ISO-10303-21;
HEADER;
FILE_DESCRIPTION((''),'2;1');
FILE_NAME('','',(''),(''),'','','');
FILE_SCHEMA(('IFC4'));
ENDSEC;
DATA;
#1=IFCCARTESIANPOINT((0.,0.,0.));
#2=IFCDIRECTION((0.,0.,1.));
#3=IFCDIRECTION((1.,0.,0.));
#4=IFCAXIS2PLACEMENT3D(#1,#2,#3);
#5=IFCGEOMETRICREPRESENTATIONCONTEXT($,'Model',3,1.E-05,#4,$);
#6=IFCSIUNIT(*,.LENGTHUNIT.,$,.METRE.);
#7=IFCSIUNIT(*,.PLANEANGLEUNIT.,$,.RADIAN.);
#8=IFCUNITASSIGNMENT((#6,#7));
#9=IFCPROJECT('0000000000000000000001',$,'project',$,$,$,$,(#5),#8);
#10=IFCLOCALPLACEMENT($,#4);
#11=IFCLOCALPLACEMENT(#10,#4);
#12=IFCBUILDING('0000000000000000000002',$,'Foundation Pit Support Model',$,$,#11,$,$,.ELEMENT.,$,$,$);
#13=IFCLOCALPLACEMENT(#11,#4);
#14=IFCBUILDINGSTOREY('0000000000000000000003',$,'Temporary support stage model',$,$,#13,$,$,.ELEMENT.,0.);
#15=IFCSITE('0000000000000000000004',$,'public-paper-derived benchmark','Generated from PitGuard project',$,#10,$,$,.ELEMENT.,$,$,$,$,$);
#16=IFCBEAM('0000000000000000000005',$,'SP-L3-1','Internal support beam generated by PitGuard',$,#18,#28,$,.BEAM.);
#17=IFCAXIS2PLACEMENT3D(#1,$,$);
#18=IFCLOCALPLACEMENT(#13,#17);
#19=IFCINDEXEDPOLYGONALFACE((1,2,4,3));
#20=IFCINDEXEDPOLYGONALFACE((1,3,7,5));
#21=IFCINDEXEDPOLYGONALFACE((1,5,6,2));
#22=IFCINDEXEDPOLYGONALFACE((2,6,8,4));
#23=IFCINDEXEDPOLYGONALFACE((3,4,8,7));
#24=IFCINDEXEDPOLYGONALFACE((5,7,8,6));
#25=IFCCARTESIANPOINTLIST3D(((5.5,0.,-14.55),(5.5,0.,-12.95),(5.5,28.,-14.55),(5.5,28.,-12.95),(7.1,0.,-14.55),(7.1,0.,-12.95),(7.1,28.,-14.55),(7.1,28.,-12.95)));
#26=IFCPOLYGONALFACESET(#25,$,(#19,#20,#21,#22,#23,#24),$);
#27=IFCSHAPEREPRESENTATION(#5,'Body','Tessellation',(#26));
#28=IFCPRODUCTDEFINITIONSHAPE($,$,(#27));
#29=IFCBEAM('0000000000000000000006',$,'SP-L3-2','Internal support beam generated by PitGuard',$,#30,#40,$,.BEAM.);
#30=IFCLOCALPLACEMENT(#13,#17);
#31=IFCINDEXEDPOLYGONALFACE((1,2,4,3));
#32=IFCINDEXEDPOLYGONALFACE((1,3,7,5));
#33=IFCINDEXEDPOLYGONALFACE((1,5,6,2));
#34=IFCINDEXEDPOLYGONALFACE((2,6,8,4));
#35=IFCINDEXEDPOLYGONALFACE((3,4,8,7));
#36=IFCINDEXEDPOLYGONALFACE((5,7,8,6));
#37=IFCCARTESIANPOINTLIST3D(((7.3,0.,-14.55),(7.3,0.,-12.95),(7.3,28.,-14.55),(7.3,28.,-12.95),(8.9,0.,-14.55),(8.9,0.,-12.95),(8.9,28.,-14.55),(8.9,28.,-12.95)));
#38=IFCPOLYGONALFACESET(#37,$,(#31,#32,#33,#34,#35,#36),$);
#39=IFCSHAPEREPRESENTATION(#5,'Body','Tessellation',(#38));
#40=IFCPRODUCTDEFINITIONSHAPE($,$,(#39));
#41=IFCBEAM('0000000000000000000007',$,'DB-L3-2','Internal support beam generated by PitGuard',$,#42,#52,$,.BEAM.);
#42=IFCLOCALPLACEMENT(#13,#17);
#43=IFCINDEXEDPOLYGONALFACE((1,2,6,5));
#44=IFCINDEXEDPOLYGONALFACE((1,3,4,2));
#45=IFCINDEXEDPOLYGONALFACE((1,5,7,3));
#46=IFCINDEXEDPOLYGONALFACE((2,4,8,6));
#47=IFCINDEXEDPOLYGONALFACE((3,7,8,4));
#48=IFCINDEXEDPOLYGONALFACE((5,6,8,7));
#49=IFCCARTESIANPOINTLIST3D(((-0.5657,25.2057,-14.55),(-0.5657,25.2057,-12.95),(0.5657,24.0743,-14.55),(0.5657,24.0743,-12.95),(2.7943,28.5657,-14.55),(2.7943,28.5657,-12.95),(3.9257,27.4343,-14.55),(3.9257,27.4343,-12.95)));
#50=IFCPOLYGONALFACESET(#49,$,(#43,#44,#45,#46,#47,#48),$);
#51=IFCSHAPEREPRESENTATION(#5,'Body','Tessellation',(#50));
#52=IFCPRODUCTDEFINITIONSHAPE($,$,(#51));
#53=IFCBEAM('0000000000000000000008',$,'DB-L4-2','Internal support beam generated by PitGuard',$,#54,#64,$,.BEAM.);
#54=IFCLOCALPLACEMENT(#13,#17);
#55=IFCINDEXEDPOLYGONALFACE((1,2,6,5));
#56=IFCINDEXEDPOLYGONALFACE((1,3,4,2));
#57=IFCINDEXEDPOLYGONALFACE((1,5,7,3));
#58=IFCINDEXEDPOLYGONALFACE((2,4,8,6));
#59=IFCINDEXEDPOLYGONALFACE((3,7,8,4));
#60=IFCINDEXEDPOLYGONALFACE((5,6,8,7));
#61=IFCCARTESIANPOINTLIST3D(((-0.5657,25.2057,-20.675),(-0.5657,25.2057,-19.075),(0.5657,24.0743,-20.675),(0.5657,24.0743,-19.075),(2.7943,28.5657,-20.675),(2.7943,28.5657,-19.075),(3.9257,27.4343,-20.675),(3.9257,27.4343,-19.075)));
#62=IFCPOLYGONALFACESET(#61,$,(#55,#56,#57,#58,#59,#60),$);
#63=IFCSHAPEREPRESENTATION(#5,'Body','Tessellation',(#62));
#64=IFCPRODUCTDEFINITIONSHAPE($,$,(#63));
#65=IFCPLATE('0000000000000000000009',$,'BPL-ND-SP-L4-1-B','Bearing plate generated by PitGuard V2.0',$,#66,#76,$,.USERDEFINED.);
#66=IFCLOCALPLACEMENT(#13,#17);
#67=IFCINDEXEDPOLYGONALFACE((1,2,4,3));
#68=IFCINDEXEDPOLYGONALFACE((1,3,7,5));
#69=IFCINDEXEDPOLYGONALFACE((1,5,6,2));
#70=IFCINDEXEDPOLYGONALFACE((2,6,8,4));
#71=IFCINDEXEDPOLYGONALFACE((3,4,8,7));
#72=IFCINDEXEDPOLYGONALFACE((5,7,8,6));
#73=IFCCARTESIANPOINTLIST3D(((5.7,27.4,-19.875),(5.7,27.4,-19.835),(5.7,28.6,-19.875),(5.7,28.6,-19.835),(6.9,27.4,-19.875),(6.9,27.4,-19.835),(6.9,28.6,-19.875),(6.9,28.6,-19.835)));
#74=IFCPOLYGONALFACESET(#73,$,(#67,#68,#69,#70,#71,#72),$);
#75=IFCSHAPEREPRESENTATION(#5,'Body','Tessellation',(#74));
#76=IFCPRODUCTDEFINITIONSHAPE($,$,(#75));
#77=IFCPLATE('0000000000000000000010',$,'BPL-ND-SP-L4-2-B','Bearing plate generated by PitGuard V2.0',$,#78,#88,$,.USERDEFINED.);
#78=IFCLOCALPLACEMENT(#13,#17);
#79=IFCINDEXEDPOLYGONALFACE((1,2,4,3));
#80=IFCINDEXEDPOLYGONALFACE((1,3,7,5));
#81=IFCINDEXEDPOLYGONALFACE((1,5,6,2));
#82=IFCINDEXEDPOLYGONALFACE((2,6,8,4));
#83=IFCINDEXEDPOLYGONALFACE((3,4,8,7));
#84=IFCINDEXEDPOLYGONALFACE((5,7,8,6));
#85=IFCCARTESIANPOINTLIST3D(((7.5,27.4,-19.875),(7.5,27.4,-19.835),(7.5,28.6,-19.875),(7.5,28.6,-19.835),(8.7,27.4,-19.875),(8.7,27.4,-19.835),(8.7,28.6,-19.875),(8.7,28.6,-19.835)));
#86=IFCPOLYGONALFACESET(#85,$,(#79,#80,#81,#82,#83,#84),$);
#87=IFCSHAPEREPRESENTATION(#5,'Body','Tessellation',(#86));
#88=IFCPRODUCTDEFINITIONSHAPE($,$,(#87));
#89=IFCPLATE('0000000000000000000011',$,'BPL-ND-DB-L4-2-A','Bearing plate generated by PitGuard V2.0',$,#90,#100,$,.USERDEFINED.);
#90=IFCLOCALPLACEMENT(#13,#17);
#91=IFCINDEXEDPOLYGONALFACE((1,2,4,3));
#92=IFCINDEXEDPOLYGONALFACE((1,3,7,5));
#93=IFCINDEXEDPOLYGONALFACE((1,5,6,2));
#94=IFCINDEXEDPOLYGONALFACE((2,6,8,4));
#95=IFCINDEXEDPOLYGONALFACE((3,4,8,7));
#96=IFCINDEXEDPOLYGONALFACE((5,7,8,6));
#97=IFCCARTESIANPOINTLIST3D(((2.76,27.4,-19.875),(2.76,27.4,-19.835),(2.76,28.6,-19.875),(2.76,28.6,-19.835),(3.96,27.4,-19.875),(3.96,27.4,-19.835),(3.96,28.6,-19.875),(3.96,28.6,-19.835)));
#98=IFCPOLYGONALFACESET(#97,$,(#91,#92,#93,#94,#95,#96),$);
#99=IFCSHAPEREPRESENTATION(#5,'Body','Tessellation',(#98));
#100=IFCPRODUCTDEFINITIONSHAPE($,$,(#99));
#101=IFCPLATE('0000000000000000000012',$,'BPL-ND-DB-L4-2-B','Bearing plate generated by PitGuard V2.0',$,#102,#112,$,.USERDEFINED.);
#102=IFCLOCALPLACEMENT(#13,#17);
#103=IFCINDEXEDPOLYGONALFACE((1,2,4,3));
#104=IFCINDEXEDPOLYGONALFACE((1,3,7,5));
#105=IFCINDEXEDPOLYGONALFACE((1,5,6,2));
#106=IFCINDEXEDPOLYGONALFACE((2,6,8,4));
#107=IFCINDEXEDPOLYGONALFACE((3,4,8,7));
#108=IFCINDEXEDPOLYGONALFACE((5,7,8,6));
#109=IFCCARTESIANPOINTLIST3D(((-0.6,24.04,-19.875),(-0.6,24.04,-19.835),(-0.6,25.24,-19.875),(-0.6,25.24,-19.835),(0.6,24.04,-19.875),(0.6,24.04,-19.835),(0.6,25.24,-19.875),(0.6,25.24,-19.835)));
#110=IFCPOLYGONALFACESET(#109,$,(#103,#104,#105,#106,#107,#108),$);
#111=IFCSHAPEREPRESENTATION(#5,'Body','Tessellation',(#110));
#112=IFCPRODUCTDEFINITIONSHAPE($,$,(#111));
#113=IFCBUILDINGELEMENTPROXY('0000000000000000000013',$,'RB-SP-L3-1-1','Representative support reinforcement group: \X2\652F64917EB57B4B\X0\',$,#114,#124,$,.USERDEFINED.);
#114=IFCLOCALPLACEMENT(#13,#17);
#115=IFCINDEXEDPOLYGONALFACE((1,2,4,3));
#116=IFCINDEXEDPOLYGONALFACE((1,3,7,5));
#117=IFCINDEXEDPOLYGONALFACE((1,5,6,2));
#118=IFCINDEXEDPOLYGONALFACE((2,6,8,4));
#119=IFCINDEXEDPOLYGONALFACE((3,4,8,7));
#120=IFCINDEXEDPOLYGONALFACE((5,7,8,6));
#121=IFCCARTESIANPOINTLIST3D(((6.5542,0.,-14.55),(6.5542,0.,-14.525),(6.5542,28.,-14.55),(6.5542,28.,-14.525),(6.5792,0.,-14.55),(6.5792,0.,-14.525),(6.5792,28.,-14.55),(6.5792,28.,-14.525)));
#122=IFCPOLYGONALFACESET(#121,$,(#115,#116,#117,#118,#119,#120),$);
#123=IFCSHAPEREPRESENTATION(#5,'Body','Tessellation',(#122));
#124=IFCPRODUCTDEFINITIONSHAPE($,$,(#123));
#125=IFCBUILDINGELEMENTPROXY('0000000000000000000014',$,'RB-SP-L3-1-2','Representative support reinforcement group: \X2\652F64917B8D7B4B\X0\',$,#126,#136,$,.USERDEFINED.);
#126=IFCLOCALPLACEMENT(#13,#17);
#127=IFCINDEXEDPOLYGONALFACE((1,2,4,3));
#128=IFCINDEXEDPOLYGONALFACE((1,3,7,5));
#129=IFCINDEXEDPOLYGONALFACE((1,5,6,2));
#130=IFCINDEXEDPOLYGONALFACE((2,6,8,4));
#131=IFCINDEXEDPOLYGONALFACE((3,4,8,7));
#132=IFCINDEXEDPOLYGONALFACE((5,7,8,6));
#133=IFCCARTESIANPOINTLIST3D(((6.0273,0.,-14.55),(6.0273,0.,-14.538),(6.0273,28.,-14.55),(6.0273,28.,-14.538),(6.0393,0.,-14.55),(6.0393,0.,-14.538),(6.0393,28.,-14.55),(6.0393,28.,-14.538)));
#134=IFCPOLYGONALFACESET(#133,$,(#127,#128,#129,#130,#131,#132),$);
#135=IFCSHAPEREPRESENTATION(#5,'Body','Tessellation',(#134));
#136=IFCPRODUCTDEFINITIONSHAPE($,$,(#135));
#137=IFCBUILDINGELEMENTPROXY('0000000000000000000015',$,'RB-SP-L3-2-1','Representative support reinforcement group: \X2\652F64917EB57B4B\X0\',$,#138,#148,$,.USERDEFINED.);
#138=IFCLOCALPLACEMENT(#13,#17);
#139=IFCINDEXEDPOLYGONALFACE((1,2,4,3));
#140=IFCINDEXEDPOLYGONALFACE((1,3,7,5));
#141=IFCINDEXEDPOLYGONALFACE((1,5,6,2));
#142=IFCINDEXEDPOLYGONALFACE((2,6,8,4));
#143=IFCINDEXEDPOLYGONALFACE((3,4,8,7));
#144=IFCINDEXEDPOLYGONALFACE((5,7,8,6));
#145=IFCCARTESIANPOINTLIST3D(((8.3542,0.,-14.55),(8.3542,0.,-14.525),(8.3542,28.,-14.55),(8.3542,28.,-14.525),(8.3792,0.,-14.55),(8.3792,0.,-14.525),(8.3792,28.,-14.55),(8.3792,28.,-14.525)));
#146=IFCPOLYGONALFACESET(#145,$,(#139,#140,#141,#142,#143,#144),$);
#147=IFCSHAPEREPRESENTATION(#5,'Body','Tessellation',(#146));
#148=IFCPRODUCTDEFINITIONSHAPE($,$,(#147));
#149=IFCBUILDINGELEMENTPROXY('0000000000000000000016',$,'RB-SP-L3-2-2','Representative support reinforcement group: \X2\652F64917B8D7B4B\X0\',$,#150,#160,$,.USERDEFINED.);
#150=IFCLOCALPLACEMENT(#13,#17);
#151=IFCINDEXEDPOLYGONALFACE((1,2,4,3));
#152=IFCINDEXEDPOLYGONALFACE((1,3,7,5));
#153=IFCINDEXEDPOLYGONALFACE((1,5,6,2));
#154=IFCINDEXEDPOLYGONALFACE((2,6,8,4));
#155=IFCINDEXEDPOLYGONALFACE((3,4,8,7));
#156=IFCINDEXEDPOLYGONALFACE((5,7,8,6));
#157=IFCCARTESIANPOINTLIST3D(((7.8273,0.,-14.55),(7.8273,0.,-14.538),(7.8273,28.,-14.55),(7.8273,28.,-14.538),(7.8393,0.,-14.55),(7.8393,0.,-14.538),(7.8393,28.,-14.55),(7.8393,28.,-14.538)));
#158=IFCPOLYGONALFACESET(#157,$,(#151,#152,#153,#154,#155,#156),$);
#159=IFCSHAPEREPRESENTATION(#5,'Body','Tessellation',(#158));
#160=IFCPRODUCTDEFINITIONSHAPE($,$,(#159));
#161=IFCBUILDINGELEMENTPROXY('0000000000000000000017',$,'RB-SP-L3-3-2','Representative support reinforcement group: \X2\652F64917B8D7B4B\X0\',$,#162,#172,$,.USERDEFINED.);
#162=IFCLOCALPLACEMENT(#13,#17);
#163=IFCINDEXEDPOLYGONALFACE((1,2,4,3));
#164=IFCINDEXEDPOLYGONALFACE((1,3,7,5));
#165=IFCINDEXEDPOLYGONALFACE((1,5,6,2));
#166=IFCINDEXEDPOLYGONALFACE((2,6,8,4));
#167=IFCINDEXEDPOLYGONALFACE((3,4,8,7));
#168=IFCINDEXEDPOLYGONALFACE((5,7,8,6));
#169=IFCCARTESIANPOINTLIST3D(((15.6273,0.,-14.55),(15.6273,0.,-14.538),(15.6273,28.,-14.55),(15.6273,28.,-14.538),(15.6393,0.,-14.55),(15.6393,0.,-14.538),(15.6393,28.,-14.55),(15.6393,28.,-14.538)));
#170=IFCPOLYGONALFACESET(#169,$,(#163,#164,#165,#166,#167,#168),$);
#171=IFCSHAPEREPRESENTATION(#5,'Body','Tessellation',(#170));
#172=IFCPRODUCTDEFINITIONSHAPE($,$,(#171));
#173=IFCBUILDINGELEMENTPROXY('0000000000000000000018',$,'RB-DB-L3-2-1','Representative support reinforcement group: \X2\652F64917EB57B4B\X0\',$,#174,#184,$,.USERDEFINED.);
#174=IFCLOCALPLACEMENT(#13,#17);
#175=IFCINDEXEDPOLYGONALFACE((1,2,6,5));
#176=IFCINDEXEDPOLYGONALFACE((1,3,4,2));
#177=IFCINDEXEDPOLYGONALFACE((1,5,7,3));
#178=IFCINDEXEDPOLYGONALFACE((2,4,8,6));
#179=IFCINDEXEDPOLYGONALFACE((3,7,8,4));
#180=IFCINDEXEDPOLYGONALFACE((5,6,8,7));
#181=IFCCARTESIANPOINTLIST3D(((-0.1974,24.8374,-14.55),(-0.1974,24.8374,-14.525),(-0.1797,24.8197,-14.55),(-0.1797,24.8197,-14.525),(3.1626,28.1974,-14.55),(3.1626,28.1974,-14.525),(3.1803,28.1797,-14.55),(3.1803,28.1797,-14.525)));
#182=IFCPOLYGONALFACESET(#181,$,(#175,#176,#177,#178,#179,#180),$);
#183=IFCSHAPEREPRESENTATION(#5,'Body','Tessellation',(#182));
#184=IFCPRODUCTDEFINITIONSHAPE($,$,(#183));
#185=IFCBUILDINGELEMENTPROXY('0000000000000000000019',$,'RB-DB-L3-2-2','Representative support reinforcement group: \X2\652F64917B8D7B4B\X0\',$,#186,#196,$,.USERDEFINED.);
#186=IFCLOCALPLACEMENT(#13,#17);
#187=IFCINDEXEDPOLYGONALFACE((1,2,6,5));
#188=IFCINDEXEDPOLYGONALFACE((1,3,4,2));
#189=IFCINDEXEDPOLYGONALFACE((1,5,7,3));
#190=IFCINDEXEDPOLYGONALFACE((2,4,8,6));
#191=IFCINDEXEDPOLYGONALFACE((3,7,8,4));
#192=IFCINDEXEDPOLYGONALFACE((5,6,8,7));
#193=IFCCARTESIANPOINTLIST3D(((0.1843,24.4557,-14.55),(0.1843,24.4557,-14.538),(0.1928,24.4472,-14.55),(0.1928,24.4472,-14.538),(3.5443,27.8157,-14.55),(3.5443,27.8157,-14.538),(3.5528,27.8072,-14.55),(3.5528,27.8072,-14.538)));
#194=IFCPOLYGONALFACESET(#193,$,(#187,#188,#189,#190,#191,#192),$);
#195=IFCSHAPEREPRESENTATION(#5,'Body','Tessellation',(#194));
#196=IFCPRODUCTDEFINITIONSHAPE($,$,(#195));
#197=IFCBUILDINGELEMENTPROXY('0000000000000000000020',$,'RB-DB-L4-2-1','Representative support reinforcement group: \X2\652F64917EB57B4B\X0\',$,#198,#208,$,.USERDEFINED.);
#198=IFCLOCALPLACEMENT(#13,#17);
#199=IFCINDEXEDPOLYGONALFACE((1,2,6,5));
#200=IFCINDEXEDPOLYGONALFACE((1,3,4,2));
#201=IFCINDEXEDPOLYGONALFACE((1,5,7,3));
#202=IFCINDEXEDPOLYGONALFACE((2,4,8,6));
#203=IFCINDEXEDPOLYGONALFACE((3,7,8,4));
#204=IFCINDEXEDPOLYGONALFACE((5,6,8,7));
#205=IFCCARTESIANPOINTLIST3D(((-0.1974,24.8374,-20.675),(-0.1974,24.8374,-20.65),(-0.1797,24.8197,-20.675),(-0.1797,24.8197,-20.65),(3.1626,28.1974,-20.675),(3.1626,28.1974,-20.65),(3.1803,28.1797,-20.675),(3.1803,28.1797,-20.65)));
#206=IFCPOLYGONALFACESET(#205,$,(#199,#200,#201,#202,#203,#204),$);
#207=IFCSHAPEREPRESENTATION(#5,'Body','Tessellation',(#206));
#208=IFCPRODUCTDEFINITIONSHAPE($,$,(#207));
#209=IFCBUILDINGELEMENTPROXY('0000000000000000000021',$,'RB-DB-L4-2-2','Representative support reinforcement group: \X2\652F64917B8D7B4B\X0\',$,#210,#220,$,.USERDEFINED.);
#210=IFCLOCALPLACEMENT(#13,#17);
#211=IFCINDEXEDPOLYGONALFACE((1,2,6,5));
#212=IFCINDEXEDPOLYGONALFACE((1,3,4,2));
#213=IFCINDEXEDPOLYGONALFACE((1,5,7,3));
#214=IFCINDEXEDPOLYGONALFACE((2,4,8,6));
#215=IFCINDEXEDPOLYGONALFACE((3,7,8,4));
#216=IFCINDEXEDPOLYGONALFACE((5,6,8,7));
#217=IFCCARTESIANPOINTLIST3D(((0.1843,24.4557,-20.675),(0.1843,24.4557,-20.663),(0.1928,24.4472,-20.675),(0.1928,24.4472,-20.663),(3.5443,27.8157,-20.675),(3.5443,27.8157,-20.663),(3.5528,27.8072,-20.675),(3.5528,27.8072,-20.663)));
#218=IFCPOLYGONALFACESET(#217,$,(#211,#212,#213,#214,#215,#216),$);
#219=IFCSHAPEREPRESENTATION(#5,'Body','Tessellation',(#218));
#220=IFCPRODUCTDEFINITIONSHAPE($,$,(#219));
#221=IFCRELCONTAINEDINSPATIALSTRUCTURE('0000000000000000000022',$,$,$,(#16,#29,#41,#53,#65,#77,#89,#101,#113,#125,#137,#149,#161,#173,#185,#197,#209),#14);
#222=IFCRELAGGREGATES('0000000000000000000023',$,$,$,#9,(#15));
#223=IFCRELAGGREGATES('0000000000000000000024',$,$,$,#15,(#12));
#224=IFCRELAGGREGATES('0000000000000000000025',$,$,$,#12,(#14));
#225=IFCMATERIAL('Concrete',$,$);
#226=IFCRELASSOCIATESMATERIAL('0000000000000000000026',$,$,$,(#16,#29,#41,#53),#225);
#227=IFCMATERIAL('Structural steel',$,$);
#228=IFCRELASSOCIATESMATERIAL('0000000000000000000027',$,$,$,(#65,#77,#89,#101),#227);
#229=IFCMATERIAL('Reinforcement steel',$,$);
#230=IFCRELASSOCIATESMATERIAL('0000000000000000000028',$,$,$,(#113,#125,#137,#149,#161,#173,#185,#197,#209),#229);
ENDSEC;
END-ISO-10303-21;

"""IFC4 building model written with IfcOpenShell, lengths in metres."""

from ifc_helpers import new_model, si_unit, frame, origin_with_axes, origin_2d, place, context, project, spatial, rectangle, extrude, material, element, save


model = new_model("IFC4")

# Units and contexts
model_context = context("Model", 3, precision=1e-05, world=origin_with_axes())
ifc_project = project(units=[si_unit("LENGTHUNIT", "METRE"), si_unit("PLANEANGLEUNIT", "RADIAN")], contexts=[model_context])

# Site, building, storey
site_placement = place(None, origin_with_axes())
site = spatial("IfcSite", under=ifc_project, at=site_placement, Name="public-paper-derived benchmark", Description="Generated from PitGuard project", CompositionType="ELEMENT")
building_placement = place(site_placement, origin_with_axes())
building = spatial("IfcBuilding", under=site, at=building_placement, Name="Foundation Pit Support Model", CompositionType="ELEMENT")
storey_placement = place(building_placement, origin_with_axes())
storey = spatial("IfcBuildingStorey", under=building, at=storey_placement, Name="Temporary support stage model", CompositionType="ELEMENT", Elevation=0.0)

# Beams
ifc_material_1 = material(Name="Concrete")
for number, where, z_axis, x_axis, name in (
    (1, (6.3, 14.0, -14.55), (0.0, 0.0, 1.0), (0.0, 1.0, 0.0), "SP-L3-1"),
    (2, (8.1, 14.0, -14.55), (0.0, 0.0, 1.0), (0.0, 1.0, 0.0), "SP-L3-2"),
):
    element("IfcBeam", number, at=place(storey_placement, frame(where, z_axis=z_axis, x_axis=x_axis)), inside=storey, material=ifc_material_1, Name=name, Description="Internal support beam generated by PitGuard", PredefinedType="BEAM", context=model_context, shape_type="SweptSolid", body=[
        extrude(rectangle(XDim=28.0, YDim=1.6, at=origin_2d()), origin_with_axes(), (0.0, 0.0, 1.0), 1.6),
    ])
for number, where, z_axis, x_axis, name in (
    (3, (1.68, 26.32, -14.55), (0.0, 0.0, 1.0), (-0.707107, -0.707107, 0.0), "DB-L3-2"),
    (4, (1.68, 26.32, -20.675), (0.0, 0.0, 1.0), (-0.707107, -0.707107, 0.0), "DB-L4-2"),
):
    element("IfcBeam", number, at=place(storey_placement, frame(where, z_axis=z_axis, x_axis=x_axis)), inside=storey, material=ifc_material_1, Name=name, Description="Internal support beam generated by PitGuard", PredefinedType="BEAM", context=model_context, shape_type="SweptSolid", body=[
        extrude(rectangle(XDim=4.7518, YDim=1.6, at=origin_2d()), origin_with_axes(), (0.0, 0.0, 1.0), 1.6),
    ])

# Plates
ifc_material_2 = material(Name="Structural steel")
for number, where, z_axis, x_axis, name in (
    (5, (6.3, 28.0, -19.875), (0.0, 0.0, 1.0), (1.0, 0.0, 0.0), "BPL-ND-SP-L4-1-B"),
    (6, (8.1, 28.0, -19.875), (0.0, 0.0, 1.0), (1.0, 0.0, 0.0), "BPL-ND-SP-L4-2-B"),
    (7, (3.36, 28.0, -19.875), (0.0, 0.0, 1.0), (1.0, 0.0, 0.0), "BPL-ND-DB-L4-2-A"),
    (8, (0.0, 24.64, -19.875), (0.0, 0.0, 1.0), (1.0, 0.0, 0.0), "BPL-ND-DB-L4-2-B"),
):
    element("IfcPlate", number, at=place(storey_placement, frame(where, z_axis=z_axis, x_axis=x_axis)), inside=storey, material=ifc_material_2, Name=name, Description="Bearing plate generated by PitGuard V2.0", PredefinedType="USERDEFINED", context=model_context, shape_type="SweptSolid", body=[
        extrude(rectangle(XDim=1.2, YDim=1.2, at=origin_2d()), origin_with_axes(), (0.0, 0.0, 1.0), 0.04),
    ])

# Building element proxies
ifc_material_3 = material(Name="Reinforcement steel")
proxy_1_placement = place(storey_placement, frame((6.5667, 14.0, -14.55), z_axis=(0.0, 0.0, 1.0), x_axis=(0.0, 1.0, 0.0)))
element("IfcBuildingElementProxy", 9, at=proxy_1_placement, inside=storey, material=ifc_material_3, Name="RB-SP-L3-1-1", Description="Representative support reinforcement group: 支撑纵筋", PredefinedType="USERDEFINED", context=model_context, shape_type="SweptSolid", body=[
    extrude(rectangle(XDim=28.0, YDim=0.025, at=origin_2d()), origin_with_axes(), (0.0, 0.0, 1.0), 0.025),
])
proxy_2_placement = place(storey_placement, frame((6.0333, 14.0, -14.55), z_axis=(0.0, 0.0, 1.0), x_axis=(0.0, 1.0, 0.0)))
element("IfcBuildingElementProxy", 10, at=proxy_2_placement, inside=storey, material=ifc_material_3, Name="RB-SP-L3-1-2", Description="Representative support reinforcement group: 支撑箍筋", PredefinedType="USERDEFINED", context=model_context, shape_type="SweptSolid", body=[
    extrude(rectangle(XDim=28.0, YDim=0.012, at=origin_2d()), origin_with_axes(), (0.0, 0.0, 1.0), 0.012),
])
proxy_3_placement = place(storey_placement, frame((8.3667, 14.0, -14.55), z_axis=(0.0, 0.0, 1.0), x_axis=(0.0, 1.0, 0.0)))
element("IfcBuildingElementProxy", 11, at=proxy_3_placement, inside=storey, material=ifc_material_3, Name="RB-SP-L3-2-1", Description="Representative support reinforcement group: 支撑纵筋", PredefinedType="USERDEFINED", context=model_context, shape_type="SweptSolid", body=[
    extrude(rectangle(XDim=28.0, YDim=0.025, at=origin_2d()), origin_with_axes(), (0.0, 0.0, 1.0), 0.025),
])
for number, where, z_axis, x_axis, name in (
    (12, (7.8333, 14.0, -14.55), (0.0, 0.0, 1.0), (0.0, 1.0, 0.0), "RB-SP-L3-2-2"),
    (13, (15.6333, 14.0, -14.55), (0.0, 0.0, 1.0), (0.0, 1.0, 0.0), "RB-SP-L3-3-2"),
):
    element("IfcBuildingElementProxy", number, at=place(storey_placement, frame(where, z_axis=z_axis, x_axis=x_axis)), inside=storey, material=ifc_material_3, Name=name, Description="Representative support reinforcement group: 支撑箍筋", PredefinedType="USERDEFINED", context=model_context, shape_type="SweptSolid", body=[
        extrude(rectangle(XDim=28.0, YDim=0.012, at=origin_2d()), origin_with_axes(), (0.0, 0.0, 1.0), 0.012),
    ])
proxy_4_placement = place(storey_placement, frame((1.4914, 26.5086, -14.55), z_axis=(0.0, 0.0, 1.0), x_axis=(-0.707107, -0.707107, 0.0)))
element("IfcBuildingElementProxy", 14, at=proxy_4_placement, inside=storey, material=ifc_material_3, Name="RB-DB-L3-2-1", Description="Representative support reinforcement group: 支撑纵筋", PredefinedType="USERDEFINED", context=model_context, shape_type="SweptSolid", body=[
    extrude(rectangle(XDim=4.7518, YDim=0.025, at=origin_2d()), origin_with_axes(), (0.0, 0.0, 1.0), 0.025),
])
proxy_5_placement = place(storey_placement, frame((1.8686, 26.1314, -14.55), z_axis=(0.0, 0.0, 1.0), x_axis=(-0.707107, -0.707107, 0.0)))
element("IfcBuildingElementProxy", 15, at=proxy_5_placement, inside=storey, material=ifc_material_3, Name="RB-DB-L3-2-2", Description="Representative support reinforcement group: 支撑箍筋", PredefinedType="USERDEFINED", context=model_context, shape_type="SweptSolid", body=[
    extrude(rectangle(XDim=4.7518, YDim=0.012, at=origin_2d()), origin_with_axes(), (0.0, 0.0, 1.0), 0.012),
])
proxy_6_placement = place(storey_placement, frame((1.4914, 26.5086, -20.675), z_axis=(0.0, 0.0, 1.0), x_axis=(-0.707107, -0.707107, 0.0)))
element("IfcBuildingElementProxy", 16, at=proxy_6_placement, inside=storey, material=ifc_material_3, Name="RB-DB-L4-2-1", Description="Representative support reinforcement group: 支撑纵筋", PredefinedType="USERDEFINED", context=model_context, shape_type="SweptSolid", body=[
    extrude(rectangle(XDim=4.7518, YDim=0.025, at=origin_2d()), origin_with_axes(), (0.0, 0.0, 1.0), 0.025),
])
proxy_7_placement = place(storey_placement, frame((1.8686, 26.1314, -20.675), z_axis=(0.0, 0.0, 1.0), x_axis=(-0.707107, -0.707107, 0.0)))
element("IfcBuildingElementProxy", 17, at=proxy_7_placement, inside=storey, material=ifc_material_3, Name="RB-DB-L4-2-2", Description="Representative support reinforcement group: 支撑箍筋", PredefinedType="USERDEFINED", context=model_context, shape_type="SweptSolid", body=[
    extrude(rectangle(XDim=4.7518, YDim=0.012, at=origin_2d()), origin_with_axes(), (0.0, 0.0, 1.0), 0.012),
])

save(model, "model.ifc")
